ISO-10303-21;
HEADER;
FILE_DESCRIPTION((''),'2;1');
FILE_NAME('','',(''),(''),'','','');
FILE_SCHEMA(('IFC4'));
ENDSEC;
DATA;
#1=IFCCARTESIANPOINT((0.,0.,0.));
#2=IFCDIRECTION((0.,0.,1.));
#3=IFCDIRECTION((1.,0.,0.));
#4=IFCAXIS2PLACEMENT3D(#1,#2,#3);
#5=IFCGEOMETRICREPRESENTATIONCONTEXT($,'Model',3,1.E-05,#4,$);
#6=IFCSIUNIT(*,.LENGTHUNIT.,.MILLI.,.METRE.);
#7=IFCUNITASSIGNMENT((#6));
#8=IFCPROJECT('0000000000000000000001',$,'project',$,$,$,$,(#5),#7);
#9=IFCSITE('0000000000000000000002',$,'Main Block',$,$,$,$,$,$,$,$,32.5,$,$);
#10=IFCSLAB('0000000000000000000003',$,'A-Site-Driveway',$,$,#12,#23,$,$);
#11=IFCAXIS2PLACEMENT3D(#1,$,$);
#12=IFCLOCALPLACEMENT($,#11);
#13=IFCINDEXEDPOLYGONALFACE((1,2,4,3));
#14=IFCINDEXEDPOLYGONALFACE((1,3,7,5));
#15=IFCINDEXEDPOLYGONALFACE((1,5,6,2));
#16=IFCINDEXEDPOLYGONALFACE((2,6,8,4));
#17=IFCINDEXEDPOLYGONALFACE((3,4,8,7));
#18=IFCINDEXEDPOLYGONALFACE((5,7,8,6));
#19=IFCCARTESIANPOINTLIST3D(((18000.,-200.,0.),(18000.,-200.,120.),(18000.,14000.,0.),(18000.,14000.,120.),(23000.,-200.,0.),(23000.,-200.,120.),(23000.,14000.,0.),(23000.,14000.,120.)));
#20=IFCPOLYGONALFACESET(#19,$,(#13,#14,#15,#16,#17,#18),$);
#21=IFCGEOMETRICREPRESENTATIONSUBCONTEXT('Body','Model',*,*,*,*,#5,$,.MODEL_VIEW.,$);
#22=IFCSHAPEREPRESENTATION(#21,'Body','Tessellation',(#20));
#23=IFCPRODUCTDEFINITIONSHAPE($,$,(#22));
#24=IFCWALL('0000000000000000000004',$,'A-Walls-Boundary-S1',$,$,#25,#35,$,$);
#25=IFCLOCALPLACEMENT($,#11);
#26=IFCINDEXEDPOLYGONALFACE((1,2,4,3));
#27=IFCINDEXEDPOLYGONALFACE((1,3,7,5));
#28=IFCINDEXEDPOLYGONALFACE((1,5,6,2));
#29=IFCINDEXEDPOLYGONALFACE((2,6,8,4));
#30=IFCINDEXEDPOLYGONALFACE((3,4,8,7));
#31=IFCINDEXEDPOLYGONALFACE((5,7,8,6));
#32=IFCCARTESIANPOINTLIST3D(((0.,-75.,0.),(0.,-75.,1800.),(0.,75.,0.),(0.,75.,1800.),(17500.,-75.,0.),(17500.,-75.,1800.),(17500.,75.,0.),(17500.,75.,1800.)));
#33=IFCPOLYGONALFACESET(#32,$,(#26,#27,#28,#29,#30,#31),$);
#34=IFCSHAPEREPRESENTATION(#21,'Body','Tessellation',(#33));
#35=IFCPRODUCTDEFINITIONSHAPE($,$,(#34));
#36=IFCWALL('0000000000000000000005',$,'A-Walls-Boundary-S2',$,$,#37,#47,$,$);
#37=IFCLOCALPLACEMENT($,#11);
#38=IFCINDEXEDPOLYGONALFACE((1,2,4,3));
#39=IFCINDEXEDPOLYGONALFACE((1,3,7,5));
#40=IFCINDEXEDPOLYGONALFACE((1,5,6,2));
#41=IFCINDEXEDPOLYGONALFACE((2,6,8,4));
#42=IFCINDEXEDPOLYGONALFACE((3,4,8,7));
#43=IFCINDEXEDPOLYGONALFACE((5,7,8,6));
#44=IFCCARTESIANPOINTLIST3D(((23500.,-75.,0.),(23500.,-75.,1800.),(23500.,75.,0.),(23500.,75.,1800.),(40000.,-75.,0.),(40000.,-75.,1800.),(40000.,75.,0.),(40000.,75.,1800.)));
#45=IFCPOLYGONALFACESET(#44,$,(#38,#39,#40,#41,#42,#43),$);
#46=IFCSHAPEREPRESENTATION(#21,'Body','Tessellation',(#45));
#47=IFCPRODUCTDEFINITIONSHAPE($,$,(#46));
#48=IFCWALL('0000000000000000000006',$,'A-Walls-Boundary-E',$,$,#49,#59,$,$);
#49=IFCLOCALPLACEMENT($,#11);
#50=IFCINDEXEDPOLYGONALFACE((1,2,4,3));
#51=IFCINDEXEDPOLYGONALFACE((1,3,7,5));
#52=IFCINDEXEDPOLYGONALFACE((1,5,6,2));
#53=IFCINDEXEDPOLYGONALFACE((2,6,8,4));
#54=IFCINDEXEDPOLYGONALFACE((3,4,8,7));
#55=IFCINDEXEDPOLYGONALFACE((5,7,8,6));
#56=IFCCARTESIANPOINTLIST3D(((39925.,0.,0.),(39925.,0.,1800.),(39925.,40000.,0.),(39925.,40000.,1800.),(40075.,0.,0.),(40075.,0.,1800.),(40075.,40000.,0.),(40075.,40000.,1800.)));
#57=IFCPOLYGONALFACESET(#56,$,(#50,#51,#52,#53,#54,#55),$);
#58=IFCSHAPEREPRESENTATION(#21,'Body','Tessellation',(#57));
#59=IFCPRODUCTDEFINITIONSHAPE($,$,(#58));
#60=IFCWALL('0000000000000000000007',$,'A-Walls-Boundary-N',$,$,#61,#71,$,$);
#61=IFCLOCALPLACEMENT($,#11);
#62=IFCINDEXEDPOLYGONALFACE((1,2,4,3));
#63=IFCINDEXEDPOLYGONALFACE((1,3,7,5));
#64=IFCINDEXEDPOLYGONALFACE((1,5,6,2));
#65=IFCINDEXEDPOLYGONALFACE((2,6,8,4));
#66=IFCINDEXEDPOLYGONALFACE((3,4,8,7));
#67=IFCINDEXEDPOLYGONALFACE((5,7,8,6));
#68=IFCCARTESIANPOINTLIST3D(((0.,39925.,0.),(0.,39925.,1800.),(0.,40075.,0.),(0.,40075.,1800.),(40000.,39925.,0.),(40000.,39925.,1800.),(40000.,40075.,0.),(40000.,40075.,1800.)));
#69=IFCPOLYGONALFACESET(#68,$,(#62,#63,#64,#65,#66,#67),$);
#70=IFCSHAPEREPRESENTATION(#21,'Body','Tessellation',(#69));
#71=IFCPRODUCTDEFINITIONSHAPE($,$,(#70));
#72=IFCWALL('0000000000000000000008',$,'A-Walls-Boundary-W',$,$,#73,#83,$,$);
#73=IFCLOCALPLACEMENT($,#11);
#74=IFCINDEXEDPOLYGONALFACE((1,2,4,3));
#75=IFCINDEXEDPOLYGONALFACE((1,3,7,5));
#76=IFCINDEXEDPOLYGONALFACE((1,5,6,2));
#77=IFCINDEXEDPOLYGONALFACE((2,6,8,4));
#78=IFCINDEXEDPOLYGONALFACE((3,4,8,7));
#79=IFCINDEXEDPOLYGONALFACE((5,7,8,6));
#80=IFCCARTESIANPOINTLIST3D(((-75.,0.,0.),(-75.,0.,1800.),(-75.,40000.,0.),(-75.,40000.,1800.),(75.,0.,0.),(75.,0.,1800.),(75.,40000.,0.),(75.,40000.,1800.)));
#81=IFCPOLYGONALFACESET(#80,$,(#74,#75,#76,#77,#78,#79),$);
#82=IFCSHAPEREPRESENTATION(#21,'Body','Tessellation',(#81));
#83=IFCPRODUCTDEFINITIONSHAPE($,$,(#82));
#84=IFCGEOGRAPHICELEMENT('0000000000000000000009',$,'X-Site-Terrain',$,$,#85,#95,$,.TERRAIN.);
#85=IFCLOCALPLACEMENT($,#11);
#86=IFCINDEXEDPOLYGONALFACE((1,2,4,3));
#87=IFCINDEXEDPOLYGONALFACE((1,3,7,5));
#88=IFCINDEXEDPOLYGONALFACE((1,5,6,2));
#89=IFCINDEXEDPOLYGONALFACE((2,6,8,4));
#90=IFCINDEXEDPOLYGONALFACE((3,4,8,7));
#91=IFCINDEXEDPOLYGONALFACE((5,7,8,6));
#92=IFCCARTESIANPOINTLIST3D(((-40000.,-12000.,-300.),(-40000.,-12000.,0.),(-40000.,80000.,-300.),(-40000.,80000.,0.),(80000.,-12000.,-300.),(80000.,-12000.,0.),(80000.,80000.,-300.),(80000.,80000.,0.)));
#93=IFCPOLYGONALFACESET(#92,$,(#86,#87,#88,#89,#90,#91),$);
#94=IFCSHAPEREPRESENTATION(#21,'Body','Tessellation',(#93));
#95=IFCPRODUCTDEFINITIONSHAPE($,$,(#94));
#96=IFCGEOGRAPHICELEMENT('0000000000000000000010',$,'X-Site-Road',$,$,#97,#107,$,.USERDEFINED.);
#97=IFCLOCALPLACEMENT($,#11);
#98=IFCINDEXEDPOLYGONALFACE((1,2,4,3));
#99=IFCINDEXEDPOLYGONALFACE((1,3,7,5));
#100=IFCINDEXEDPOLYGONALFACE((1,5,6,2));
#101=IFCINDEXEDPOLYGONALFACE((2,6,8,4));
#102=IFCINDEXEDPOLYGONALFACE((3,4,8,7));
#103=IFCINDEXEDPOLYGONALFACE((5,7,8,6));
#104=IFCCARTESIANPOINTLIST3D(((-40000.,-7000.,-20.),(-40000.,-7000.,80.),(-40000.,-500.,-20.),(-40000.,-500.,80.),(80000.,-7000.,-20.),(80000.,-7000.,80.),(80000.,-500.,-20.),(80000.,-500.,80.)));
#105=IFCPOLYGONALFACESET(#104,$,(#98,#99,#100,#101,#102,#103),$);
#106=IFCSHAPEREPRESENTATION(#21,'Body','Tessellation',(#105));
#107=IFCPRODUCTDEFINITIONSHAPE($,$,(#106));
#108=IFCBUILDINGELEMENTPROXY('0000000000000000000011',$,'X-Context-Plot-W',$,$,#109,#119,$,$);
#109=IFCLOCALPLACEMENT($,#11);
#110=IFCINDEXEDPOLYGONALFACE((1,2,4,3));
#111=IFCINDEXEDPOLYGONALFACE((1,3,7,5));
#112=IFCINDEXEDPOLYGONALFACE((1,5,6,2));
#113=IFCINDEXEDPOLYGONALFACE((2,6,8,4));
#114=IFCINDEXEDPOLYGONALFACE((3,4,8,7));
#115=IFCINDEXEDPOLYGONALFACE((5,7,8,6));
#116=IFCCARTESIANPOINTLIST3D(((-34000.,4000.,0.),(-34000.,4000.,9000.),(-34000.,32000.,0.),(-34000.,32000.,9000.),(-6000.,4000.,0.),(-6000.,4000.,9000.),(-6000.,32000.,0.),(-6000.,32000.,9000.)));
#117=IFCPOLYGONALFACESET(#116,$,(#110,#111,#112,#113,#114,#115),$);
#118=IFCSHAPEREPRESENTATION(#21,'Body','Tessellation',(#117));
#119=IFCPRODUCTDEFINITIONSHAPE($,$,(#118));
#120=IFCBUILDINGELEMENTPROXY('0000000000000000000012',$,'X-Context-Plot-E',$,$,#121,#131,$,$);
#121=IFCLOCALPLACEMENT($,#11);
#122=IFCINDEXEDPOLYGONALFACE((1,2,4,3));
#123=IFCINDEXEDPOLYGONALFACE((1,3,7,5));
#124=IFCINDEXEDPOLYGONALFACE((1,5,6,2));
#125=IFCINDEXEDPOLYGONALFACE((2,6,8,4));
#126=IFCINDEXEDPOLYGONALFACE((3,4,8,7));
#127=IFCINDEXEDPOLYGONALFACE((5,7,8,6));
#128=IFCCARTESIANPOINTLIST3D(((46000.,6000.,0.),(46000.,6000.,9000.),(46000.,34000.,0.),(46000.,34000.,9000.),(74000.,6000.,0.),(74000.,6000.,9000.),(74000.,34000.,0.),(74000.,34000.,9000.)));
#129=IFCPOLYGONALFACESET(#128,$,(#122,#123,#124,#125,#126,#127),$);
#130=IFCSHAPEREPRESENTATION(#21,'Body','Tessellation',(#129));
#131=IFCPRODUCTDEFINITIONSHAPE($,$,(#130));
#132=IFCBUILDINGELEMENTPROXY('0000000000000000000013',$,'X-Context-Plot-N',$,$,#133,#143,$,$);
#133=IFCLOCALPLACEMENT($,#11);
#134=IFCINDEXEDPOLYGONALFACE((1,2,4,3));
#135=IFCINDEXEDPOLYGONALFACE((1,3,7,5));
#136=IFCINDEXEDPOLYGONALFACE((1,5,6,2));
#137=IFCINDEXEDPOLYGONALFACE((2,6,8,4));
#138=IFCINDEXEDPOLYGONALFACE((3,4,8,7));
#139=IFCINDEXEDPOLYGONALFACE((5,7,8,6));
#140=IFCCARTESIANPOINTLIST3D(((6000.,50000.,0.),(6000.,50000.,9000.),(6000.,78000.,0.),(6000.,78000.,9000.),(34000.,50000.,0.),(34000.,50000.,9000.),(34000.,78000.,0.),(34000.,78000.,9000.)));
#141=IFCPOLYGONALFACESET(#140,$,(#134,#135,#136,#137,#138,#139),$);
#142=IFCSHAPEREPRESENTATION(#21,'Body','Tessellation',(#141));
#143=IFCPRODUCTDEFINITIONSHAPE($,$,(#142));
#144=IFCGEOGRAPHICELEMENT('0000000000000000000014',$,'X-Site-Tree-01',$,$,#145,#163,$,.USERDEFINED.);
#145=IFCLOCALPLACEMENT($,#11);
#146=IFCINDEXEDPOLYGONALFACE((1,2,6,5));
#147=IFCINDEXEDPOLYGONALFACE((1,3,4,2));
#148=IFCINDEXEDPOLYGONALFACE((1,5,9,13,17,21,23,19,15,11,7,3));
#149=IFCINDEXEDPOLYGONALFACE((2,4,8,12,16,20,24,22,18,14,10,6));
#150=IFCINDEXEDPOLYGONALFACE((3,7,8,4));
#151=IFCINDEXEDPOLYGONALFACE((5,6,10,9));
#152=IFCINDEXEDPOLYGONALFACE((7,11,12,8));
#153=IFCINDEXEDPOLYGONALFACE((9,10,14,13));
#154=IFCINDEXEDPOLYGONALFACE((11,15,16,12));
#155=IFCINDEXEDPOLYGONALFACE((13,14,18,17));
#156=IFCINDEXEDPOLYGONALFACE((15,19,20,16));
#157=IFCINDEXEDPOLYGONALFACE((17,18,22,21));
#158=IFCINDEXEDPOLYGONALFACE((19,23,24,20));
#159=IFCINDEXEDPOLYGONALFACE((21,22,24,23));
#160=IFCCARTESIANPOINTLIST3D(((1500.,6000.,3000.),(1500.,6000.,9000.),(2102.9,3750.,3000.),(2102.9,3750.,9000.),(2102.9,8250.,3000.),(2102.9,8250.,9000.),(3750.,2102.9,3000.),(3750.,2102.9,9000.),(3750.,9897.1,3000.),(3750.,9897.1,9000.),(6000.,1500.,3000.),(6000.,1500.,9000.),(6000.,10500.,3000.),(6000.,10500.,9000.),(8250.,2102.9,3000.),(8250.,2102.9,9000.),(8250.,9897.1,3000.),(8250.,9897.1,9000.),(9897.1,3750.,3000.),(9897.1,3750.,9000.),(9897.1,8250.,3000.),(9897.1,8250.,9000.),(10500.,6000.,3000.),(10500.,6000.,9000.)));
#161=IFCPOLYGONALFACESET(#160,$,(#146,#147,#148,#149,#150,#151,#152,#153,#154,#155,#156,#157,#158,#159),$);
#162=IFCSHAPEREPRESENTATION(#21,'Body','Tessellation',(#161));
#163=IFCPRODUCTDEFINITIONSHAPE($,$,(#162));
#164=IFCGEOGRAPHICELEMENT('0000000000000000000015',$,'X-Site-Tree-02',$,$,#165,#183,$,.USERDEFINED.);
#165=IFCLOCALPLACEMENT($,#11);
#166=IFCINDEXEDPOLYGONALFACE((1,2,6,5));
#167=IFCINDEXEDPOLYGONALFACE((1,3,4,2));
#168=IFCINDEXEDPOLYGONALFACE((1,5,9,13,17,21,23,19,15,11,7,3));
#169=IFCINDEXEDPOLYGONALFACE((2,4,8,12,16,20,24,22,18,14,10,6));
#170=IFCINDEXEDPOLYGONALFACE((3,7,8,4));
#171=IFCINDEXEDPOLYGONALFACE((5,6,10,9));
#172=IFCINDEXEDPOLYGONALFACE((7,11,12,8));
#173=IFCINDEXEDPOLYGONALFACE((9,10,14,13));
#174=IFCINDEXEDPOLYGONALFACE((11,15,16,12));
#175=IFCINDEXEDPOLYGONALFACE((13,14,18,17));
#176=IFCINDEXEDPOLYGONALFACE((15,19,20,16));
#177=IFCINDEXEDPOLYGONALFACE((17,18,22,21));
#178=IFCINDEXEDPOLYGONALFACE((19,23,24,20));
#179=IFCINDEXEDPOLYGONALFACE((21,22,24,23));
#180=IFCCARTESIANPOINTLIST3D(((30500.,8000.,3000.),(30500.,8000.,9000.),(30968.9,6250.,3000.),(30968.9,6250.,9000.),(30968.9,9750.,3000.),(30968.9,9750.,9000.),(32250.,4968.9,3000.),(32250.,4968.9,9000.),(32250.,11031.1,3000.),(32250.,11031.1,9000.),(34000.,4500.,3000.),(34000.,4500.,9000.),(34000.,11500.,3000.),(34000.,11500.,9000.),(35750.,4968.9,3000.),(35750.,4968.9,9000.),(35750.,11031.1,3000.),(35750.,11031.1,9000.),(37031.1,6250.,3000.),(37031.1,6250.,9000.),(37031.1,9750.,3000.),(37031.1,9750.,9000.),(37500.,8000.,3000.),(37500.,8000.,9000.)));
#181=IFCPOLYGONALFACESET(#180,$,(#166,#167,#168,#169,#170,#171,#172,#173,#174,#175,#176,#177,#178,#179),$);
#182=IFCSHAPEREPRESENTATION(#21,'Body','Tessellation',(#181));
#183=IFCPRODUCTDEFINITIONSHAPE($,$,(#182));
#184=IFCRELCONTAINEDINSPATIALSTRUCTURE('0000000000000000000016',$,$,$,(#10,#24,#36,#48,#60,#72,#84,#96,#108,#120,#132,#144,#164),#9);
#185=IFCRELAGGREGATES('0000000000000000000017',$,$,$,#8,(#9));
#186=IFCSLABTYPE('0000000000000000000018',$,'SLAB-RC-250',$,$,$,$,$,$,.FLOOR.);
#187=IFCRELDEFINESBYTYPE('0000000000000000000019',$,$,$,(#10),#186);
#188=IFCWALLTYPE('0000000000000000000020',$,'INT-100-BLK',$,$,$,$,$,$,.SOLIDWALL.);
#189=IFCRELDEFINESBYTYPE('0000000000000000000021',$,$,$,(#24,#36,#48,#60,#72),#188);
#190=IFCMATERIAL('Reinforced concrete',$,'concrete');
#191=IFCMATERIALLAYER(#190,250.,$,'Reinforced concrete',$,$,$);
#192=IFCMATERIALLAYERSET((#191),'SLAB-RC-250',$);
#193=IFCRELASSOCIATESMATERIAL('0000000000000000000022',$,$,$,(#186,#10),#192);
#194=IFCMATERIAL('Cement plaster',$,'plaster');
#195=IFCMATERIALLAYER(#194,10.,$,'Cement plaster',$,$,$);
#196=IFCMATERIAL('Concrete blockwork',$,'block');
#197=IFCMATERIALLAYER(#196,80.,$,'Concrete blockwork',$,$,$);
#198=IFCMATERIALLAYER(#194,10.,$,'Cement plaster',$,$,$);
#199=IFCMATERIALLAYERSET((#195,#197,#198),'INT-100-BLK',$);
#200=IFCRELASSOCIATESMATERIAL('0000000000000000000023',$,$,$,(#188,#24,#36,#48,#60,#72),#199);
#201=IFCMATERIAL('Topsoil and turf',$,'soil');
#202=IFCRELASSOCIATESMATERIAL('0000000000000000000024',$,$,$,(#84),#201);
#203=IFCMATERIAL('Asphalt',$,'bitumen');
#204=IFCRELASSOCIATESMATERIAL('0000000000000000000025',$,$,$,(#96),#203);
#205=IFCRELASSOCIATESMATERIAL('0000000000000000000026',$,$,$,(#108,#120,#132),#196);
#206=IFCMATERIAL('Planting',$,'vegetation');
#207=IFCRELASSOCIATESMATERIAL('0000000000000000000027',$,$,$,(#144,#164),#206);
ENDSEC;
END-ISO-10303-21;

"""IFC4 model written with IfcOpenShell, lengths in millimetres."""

from ifc_helpers import new_model, si_unit, frame, origin_with_axes, place, context, subcontext, project, spatial, indexed_curve, outline, extrude, material, layer, layer_set, layer_usage, type_object, element, save


model = new_model("IFC4")

# Units and contexts
model_context = context("Model", 3, precision=1e-05, world=origin_with_axes())
body_context = subcontext(model_context, "Body", "Model", "MODEL_VIEW")
ifc_project = project(units=[si_unit("LENGTHUNIT", "METRE", prefix="MILLI")], contexts=[model_context])

# Site
site = spatial("IfcSite", under=ifc_project, Name="Main Block", RefElevation=32.5)

# Slab
ifc_material_1 = material(Name="Reinforced concrete", Category="concrete")
ifc_layer_1 = layer(ifc_material_1, 250.0, Name="Reinforced concrete")
ifc_layer_set_1 = layer_set([ifc_layer_1], Name="SLAB-RC-250")
ifc_layer_usage_1 = layer_usage(ifc_layer_set_1, "AXIS3", "POSITIVE", 0.0)
slab_type = type_object("IfcSlabType", Name="SLAB-RC-250", PredefinedType="FLOOR", material=ifc_layer_set_1)
slab_placement = place(None, origin_with_axes())
element("IfcSlab", 1, at=slab_placement, inside=site, type_object=slab_type, material=ifc_layer_usage_1, Name="A-Site-Driveway", context=body_context, shape_type="SweptSolid", body=[
    extrude(outline(indexed_curve([(18000.0, -200.0), (23000.0, -200.0), (23000.0, 14000.0), (18000.0, 14000.0)])), None, (0.0, 0.0, 1.0), 120.0),
])

# Walls
ifc_material_2 = material(Name="Cement plaster", Category="plaster")
ifc_layer_2 = layer(ifc_material_2, 10.0, Name="Cement plaster")
ifc_material_3 = material(Name="Concrete blockwork", Category="block")
ifc_layer_3 = layer(ifc_material_3, 80.0, Name="Concrete blockwork")
ifc_layer_4 = layer(ifc_material_2, 10.0, Name="Cement plaster")
ifc_layer_set_2 = layer_set([ifc_layer_2, ifc_layer_3, ifc_layer_4], Name="INT-100-BLK")
ifc_layer_usage_2 = layer_usage(ifc_layer_set_2, "AXIS2", "POSITIVE", 0.0)
wall_type = type_object("IfcWallType", Name="INT-100-BLK", PredefinedType="SOLIDWALL", material=ifc_layer_set_2)
wall_1_placement = place(None, frame((0.0, -75.0, 0.0), z_axis=(0.0, 0.0, 1.0), x_axis=(1.0, 0.0, 0.0)))
element("IfcWall", 2, at=wall_1_placement, inside=site, type_object=wall_type, material=ifc_layer_usage_2, Name="A-Walls-Boundary-S1", context=body_context, shape_type="SweptSolid", body=[
    extrude(outline(indexed_curve([(0.0, 0.0), (0.0, 150.0), (17500.0, 150.0), (17500.0, 0.0), (0.0, 0.0)], self_intersect=False)), origin_with_axes(), (0.0, 0.0, 1.0), 1800.0),
])
ifc_layer_usage_3 = layer_usage(ifc_layer_set_2, "AXIS2", "POSITIVE", 0.0)
wall_2_placement = place(None, frame((23500.0, -75.0, 0.0), z_axis=(0.0, 0.0, 1.0), x_axis=(1.0, 0.0, 0.0)))
element("IfcWall", 3, at=wall_2_placement, inside=site, type_object=wall_type, material=ifc_layer_usage_3, Name="A-Walls-Boundary-S2", context=body_context, shape_type="SweptSolid", body=[
    extrude(outline(indexed_curve([(0.0, 0.0), (0.0, 150.0), (16500.0, 150.0), (16500.0, 0.0), (0.0, 0.0)], self_intersect=False)), origin_with_axes(), (0.0, 0.0, 1.0), 1800.0),
])
ifc_layer_usage_4 = layer_usage(ifc_layer_set_2, "AXIS2", "POSITIVE", 0.0)
wall_3_placement = place(None, frame((40075.0, 0.0, 0.0), z_axis=(0.0, 0.0, 1.0), x_axis=(0.0, 1.0, 0.0)))
element("IfcWall", 4, at=wall_3_placement, inside=site, type_object=wall_type, material=ifc_layer_usage_4, Name="A-Walls-Boundary-E", context=body_context, shape_type="SweptSolid", body=[
    extrude(outline(indexed_curve([(0.0, 0.0), (0.0, 150.0), (40000.0, 150.0), (40000.0, 0.0), (0.0, 0.0)], self_intersect=False)), origin_with_axes(), (0.0, 0.0, 1.0), 1800.0),
])
ifc_layer_usage_5 = layer_usage(ifc_layer_set_2, "AXIS2", "POSITIVE", 0.0)
wall_4_placement = place(None, frame((40000.0, 40075.0, 0.0), z_axis=(0.0, 0.0, 1.0), x_axis=(-1.0, 0.0, 0.0)))
element("IfcWall", 5, at=wall_4_placement, inside=site, type_object=wall_type, material=ifc_layer_usage_5, Name="A-Walls-Boundary-N", context=body_context, shape_type="SweptSolid", body=[
    extrude(outline(indexed_curve([(0.0, 0.0), (0.0, 150.0), (40000.0, 150.0), (40000.0, 0.0), (0.0, 0.0)], self_intersect=False)), origin_with_axes(), (0.0, 0.0, 1.0), 1800.0),
])
ifc_layer_usage_6 = layer_usage(ifc_layer_set_2, "AXIS2", "POSITIVE", 0.0)
wall_5_placement = place(None, frame((-75.0, 40000.0, 0.0), z_axis=(0.0, 0.0, 1.0), x_axis=(0.0, -1.0, 0.0)))
element("IfcWall", 6, at=wall_5_placement, inside=site, type_object=wall_type, material=ifc_layer_usage_6, Name="A-Walls-Boundary-W", context=body_context, shape_type="SweptSolid", body=[
    extrude(outline(indexed_curve([(0.0, 0.0), (0.0, 150.0), (40000.0, 150.0), (40000.0, 0.0), (0.0, 0.0)], self_intersect=False)), origin_with_axes(), (0.0, 0.0, 1.0), 1800.0),
])

# Geographic elements
ifc_material_4 = material(Name="Topsoil and turf", Category="soil")
geographic_element_1_placement = place(None, frame((0.0, 0.0, -300.0), z_axis=(0.0, 0.0, 1.0), x_axis=(1.0, 0.0, 0.0)))
element("IfcGeographicElement", 7, at=geographic_element_1_placement, inside=site, material=ifc_material_4, Name="X-Site-Terrain", PredefinedType="TERRAIN", context=body_context, shape_type="SweptSolid", body=[
    extrude(outline(indexed_curve([(-40000.0, -12000.0), (80000.0, -12000.0), (80000.0, 80000.0), (-40000.0, 80000.0)])), None, (0.0, 0.0, 1.0), 300.0),
])
ifc_material_5 = material(Name="Asphalt", Category="bitumen")
geographic_element_2_placement = place(None, frame((0.0, 0.0, -20.0), z_axis=(0.0, 0.0, 1.0), x_axis=(1.0, 0.0, 0.0)))
element("IfcGeographicElement", 8, at=geographic_element_2_placement, inside=site, material=ifc_material_5, Name="X-Site-Road", PredefinedType="USERDEFINED", context=body_context, shape_type="SweptSolid", body=[
    extrude(outline(indexed_curve([(-40000.0, -7000.0), (80000.0, -7000.0), (80000.0, -500.0), (-40000.0, -500.0)])), None, (0.0, 0.0, 1.0), 100.0),
])

# Building element proxies
proxy_1_placement = place(None, origin_with_axes())
element("IfcBuildingElementProxy", 9, at=proxy_1_placement, inside=site, material=ifc_material_3, Name="X-Context-Plot-W", context=body_context, shape_type="SweptSolid", body=[
    extrude(outline(indexed_curve([(-34000.0, 4000.0), (-6000.0, 4000.0), (-6000.0, 32000.0), (-34000.0, 32000.0)])), None, (0.0, 0.0, 1.0), 9000.0),
])
proxy_2_placement = place(None, origin_with_axes())
element("IfcBuildingElementProxy", 10, at=proxy_2_placement, inside=site, material=ifc_material_3, Name="X-Context-Plot-E", context=body_context, shape_type="SweptSolid", body=[
    extrude(outline(indexed_curve([(46000.0, 6000.0), (74000.0, 6000.0), (74000.0, 34000.0), (46000.0, 34000.0)])), None, (0.0, 0.0, 1.0), 9000.0),
])
proxy_3_placement = place(None, origin_with_axes())
element("IfcBuildingElementProxy", 11, at=proxy_3_placement, inside=site, material=ifc_material_3, Name="X-Context-Plot-N", context=body_context, shape_type="SweptSolid", body=[
    extrude(outline(indexed_curve([(6000.0, 50000.0), (34000.0, 50000.0), (34000.0, 78000.0), (6000.0, 78000.0)])), None, (0.0, 0.0, 1.0), 9000.0),
])

# Geographic elements
ifc_material_6 = material(Name="Planting", Category="vegetation")
geographic_element_3_placement = place(None, frame((0.0, 0.0, 3000.0), z_axis=(0.0, 0.0, 1.0), x_axis=(1.0, 0.0, 0.0)))
element("IfcGeographicElement", 12, at=geographic_element_3_placement, inside=site, material=ifc_material_6, Name="X-Site-Tree-01", PredefinedType="USERDEFINED", context=body_context, shape_type="SweptSolid", body=[
    extrude(outline(indexed_curve([(10500.0, 6000.0), (9897.1, 8250.0), (8250.0, 9897.1), (6000.0, 10500.0), (3750.0, 9897.1), (2102.9, 8250.0), (1500.0, 6000.0), (2102.9, 3750.0), (3750.0, 2102.9), (6000.0, 1500.0), (8250.0, 2102.9), (9897.1, 3750.0)])), None, (0.0, 0.0, 1.0), 6000.0),
])
geographic_element_4_placement = place(None, frame((0.0, 0.0, 3000.0), z_axis=(0.0, 0.0, 1.0), x_axis=(1.0, 0.0, 0.0)))
element("IfcGeographicElement", 13, at=geographic_element_4_placement, inside=site, material=ifc_material_6, Name="X-Site-Tree-02", PredefinedType="USERDEFINED", context=body_context, shape_type="SweptSolid", body=[
    extrude(outline(indexed_curve([(37500.0, 8000.0), (37031.1, 9750.0), (35750.0, 11031.1), (34000.0, 11500.0), (32250.0, 11031.1), (30968.9, 9750.0), (30500.0, 8000.0), (30968.9, 6250.0), (32250.0, 4968.9), (34000.0, 4500.0), (35750.0, 4968.9), (37031.1, 6250.0)])), None, (0.0, 0.0, 1.0), 6000.0),
])

save(model, "model.ifc")
